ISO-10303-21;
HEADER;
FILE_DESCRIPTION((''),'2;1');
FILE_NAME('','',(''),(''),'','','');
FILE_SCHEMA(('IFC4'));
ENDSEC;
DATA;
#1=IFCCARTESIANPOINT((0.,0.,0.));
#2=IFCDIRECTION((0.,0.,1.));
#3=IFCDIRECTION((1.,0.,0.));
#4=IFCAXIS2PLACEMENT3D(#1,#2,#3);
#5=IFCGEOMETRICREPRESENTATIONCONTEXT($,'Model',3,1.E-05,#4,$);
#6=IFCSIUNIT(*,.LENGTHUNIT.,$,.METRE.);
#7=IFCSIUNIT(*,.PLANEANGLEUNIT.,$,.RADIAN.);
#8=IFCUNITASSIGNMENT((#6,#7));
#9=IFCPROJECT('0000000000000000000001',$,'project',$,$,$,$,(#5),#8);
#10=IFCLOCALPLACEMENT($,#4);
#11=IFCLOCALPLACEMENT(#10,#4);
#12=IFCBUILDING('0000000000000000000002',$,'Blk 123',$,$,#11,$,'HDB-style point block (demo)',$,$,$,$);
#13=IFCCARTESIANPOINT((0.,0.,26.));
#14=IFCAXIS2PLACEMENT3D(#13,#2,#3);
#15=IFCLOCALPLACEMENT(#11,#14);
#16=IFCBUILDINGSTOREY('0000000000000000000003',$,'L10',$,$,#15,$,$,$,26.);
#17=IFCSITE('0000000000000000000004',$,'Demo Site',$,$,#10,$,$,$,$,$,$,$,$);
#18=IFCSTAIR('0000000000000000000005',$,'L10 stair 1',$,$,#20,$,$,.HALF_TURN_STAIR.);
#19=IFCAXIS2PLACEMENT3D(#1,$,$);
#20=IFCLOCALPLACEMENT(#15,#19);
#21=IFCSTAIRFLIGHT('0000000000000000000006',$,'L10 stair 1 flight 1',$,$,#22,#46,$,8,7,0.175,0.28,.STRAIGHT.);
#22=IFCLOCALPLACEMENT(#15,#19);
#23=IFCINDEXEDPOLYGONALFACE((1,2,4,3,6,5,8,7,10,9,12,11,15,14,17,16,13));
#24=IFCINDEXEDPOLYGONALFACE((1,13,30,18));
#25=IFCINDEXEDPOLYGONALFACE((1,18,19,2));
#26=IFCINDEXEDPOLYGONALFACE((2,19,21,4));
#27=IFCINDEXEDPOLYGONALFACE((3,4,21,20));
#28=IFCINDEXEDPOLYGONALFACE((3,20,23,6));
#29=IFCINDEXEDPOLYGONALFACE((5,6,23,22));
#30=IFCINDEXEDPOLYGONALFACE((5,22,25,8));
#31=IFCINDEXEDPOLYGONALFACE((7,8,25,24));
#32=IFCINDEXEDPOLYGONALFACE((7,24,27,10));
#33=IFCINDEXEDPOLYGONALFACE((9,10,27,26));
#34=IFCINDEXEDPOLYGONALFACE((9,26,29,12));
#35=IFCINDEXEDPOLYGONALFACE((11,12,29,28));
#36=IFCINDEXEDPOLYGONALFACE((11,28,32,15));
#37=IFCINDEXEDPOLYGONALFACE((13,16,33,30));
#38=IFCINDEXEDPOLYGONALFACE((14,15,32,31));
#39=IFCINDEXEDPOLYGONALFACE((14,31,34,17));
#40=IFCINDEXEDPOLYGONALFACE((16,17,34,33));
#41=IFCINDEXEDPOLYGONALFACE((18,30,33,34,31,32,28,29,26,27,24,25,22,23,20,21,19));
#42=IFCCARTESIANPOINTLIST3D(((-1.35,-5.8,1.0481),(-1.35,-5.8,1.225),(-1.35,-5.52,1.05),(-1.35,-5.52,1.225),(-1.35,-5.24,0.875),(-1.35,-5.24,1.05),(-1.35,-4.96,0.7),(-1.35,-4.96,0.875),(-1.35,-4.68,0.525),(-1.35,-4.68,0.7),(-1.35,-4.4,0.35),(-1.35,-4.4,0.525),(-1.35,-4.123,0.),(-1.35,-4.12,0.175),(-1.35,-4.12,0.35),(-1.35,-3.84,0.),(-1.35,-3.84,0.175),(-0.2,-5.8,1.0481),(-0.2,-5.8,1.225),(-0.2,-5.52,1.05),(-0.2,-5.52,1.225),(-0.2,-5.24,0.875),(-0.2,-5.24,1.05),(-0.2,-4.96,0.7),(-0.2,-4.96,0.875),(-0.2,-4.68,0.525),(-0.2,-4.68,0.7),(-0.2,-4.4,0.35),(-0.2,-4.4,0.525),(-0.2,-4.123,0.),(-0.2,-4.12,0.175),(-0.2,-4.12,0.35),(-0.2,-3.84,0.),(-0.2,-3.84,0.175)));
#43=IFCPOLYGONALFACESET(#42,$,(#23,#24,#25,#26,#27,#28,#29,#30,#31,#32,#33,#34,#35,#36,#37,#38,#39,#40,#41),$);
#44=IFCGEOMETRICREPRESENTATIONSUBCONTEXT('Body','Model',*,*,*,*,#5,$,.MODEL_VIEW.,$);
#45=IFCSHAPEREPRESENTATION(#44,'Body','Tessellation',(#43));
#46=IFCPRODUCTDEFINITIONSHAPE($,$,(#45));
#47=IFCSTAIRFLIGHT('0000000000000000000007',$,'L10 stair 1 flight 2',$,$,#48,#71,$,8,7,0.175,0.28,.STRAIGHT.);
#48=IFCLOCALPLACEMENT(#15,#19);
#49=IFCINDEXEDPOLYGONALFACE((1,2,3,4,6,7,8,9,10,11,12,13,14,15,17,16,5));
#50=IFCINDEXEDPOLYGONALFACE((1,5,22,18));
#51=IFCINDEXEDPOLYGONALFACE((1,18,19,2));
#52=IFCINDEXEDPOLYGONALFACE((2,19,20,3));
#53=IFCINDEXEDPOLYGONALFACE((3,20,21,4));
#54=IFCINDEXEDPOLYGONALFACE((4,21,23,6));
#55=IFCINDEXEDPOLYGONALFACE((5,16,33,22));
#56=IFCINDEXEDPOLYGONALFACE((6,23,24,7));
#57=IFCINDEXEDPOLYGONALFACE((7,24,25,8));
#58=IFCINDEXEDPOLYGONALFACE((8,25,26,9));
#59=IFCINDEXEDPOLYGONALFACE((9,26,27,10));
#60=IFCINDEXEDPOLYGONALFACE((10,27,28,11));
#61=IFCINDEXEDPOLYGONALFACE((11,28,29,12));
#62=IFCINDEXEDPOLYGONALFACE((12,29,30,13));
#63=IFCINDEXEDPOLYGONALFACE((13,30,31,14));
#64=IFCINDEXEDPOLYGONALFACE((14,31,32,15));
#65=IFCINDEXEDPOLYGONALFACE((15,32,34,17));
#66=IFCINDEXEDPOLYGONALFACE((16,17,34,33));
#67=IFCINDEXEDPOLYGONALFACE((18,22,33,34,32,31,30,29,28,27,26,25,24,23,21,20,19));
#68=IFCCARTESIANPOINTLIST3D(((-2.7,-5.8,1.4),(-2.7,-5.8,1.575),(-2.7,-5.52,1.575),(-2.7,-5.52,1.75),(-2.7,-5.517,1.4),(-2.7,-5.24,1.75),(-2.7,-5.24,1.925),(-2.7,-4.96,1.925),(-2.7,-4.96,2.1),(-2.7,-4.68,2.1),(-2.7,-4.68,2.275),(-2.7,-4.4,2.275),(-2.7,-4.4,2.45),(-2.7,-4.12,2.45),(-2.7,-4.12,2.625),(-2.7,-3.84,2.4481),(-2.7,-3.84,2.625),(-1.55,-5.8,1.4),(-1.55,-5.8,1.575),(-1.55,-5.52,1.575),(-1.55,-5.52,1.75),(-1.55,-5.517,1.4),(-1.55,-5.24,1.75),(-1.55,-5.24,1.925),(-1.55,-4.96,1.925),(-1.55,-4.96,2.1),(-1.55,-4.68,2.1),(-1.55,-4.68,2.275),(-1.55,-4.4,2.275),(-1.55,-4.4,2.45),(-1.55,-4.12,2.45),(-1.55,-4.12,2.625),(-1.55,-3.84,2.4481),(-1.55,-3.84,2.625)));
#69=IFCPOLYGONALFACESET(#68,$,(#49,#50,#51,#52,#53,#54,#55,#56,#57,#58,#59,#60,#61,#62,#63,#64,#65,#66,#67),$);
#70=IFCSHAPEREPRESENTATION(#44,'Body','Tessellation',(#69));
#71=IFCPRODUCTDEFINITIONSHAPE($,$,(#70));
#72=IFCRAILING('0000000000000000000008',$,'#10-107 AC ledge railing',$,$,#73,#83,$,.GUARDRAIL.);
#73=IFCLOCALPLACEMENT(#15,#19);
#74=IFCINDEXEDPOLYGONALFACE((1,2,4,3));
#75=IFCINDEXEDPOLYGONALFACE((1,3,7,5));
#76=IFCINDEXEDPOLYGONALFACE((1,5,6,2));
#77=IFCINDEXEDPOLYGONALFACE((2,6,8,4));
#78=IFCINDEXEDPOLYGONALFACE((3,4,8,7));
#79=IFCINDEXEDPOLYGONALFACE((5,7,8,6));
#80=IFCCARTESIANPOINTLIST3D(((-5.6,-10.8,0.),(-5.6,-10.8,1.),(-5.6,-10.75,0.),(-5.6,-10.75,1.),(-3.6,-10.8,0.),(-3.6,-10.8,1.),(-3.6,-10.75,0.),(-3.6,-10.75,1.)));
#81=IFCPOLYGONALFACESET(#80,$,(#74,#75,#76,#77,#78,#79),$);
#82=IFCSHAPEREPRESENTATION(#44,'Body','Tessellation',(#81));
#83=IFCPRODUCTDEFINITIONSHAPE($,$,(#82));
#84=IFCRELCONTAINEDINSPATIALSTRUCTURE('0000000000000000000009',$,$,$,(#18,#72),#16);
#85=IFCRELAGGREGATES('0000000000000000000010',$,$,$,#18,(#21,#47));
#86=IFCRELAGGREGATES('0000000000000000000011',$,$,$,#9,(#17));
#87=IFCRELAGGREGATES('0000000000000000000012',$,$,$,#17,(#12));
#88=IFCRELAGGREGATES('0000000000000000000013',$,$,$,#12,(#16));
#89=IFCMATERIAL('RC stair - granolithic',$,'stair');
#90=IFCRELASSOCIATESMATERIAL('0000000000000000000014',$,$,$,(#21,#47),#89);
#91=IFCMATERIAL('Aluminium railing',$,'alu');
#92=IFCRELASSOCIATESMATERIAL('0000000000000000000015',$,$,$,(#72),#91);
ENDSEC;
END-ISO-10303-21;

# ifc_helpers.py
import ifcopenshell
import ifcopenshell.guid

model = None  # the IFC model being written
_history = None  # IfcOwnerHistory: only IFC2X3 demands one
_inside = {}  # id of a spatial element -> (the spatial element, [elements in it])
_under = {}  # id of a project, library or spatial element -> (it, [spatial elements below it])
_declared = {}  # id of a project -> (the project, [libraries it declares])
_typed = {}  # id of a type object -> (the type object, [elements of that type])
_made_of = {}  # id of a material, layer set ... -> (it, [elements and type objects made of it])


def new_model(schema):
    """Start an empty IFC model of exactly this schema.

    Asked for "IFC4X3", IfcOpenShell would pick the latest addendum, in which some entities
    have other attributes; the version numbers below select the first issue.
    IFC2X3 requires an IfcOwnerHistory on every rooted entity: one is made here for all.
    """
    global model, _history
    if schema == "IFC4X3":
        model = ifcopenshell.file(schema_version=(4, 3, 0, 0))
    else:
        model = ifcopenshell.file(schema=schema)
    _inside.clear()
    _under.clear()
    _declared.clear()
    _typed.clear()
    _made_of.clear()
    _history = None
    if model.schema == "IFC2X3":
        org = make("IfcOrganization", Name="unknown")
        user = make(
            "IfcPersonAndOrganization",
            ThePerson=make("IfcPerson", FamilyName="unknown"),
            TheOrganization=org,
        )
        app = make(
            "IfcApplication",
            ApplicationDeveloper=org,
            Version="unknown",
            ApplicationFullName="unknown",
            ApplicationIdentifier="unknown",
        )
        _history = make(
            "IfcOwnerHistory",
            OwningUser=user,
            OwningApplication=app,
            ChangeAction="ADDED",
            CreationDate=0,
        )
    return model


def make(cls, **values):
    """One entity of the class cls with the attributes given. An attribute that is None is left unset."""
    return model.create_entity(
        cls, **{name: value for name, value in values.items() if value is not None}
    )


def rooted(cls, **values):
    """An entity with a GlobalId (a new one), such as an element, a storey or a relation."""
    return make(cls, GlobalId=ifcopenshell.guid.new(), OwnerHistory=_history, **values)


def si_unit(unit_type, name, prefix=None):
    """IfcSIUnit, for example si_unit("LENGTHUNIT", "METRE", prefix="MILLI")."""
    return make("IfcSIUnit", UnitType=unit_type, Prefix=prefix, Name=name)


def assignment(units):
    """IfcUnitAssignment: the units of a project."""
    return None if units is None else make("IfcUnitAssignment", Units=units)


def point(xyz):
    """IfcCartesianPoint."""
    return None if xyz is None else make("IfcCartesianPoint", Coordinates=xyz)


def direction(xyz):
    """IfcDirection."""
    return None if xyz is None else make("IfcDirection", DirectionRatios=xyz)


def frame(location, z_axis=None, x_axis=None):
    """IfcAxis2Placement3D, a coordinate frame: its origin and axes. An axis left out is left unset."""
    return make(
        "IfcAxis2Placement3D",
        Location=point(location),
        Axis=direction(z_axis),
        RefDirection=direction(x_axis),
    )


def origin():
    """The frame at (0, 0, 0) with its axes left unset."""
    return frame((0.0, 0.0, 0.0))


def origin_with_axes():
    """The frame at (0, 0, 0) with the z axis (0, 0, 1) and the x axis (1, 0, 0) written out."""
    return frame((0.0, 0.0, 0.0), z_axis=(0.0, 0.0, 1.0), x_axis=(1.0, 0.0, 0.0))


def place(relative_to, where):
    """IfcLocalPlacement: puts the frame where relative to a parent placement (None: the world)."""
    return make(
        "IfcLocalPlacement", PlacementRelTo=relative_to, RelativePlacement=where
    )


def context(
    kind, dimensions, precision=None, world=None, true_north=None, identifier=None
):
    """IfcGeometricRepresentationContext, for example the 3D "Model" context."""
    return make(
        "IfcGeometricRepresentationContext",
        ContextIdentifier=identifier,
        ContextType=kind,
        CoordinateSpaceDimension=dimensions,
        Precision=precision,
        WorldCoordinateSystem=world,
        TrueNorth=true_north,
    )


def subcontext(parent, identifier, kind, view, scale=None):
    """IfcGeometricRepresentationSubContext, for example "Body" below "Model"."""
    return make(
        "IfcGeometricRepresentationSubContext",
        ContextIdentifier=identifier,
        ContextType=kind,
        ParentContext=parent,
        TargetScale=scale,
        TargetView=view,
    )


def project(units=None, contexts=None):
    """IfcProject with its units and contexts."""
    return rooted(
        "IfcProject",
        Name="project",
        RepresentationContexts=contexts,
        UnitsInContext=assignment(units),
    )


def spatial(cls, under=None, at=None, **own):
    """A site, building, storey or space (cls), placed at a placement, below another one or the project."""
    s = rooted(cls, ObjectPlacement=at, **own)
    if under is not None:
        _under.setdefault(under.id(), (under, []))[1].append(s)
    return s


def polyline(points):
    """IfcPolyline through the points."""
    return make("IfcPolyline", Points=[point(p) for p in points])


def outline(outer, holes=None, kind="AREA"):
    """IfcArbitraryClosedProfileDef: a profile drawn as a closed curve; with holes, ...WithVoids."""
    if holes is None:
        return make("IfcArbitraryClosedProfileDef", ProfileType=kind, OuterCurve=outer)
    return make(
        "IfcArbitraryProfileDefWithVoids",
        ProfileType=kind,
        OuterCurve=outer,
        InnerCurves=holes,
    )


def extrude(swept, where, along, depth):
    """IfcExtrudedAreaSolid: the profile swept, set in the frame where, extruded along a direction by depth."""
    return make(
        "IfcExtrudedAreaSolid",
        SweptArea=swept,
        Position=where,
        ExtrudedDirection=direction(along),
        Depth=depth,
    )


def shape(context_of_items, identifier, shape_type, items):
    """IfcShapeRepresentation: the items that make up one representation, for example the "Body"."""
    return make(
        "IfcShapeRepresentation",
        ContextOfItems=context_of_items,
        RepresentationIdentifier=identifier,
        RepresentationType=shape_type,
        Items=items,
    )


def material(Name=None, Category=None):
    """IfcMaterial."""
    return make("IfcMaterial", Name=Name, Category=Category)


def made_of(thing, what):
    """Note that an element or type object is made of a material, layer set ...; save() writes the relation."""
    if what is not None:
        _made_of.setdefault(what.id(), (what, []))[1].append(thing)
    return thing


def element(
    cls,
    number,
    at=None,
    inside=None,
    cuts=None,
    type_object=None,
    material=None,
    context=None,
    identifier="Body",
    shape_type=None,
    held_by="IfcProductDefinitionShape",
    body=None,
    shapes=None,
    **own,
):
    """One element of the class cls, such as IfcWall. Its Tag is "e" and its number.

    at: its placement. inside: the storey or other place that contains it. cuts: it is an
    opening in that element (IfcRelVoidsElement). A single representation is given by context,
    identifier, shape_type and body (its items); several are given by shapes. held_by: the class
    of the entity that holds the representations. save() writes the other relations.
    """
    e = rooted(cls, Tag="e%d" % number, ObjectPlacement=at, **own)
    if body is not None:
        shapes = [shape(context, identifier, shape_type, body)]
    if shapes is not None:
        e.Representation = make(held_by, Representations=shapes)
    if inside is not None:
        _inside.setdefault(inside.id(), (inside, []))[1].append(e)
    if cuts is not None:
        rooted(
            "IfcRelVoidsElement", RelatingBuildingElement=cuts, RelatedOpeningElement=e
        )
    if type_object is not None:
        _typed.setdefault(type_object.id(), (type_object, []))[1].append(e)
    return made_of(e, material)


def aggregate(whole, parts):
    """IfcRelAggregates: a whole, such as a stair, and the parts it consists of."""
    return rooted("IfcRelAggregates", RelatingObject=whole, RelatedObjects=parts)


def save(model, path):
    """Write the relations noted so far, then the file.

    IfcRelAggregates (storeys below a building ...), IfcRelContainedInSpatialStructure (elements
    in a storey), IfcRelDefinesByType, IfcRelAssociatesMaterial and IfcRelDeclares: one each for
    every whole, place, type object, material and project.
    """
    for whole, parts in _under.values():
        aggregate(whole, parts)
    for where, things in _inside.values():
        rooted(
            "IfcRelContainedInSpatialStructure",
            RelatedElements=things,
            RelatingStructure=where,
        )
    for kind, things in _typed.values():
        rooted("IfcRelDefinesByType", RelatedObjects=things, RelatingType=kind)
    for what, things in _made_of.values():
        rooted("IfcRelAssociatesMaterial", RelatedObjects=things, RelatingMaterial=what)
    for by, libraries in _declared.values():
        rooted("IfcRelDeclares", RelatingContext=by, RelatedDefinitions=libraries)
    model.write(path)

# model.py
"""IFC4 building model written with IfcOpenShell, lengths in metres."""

from ifc_helpers import new_model, si_unit, frame, origin, origin_with_axes, place, context, subcontext, project, spatial, polyline, outline, extrude, material, element, aggregate, save


model = new_model("IFC4")

# Units and contexts
model_context = context("Model", 3, precision=1e-05, world=origin_with_axes())
body_context = subcontext(model_context, "Body", "Model", "MODEL_VIEW")
ifc_project = project(units=[si_unit("LENGTHUNIT", "METRE"), si_unit("PLANEANGLEUNIT", "RADIAN")], contexts=[model_context])

# Site, building, storey
site_placement = place(None, origin_with_axes())
site = spatial("IfcSite", under=ifc_project, at=site_placement, Name="Demo Site")
building_placement = place(site_placement, origin_with_axes())
building = spatial("IfcBuilding", under=site, at=building_placement, Name="Blk 123", LongName="HDB-style point block (demo)")
storey_placement = place(building_placement, frame((0.0, 0.0, 26.0), z_axis=(0.0, 0.0, 1.0), x_axis=(1.0, 0.0, 0.0)))
storey = spatial("IfcBuildingStorey", under=building, at=storey_placement, Name="L10", Elevation=26.0)

# Stair
stair_placement = place(storey_placement, frame((-2.7, -7.1, 0.0), z_axis=(0.0, 0.0, 1.0), x_axis=(1.0, 0.0, 0.0)))
stair = element("IfcStair", 1, at=stair_placement, inside=storey, Name="L10 stair 1", PredefinedType="HALF_TURN_STAIR")
ifc_material_1 = material(Name="RC stair - granolithic", Category="stair")

# Stair flights
stair_flight_1_placement = place(stair_placement, frame((2.5, 3.26, 0.0), z_axis=(0.0, 0.0, 1.0), x_axis=(1.0, 0.0, 0.0)))
stair_flight_1 = element("IfcStairFlight", 2, at=stair_flight_1_placement, material=ifc_material_1, Name="L10 stair 1 flight 1", NumberOfRisers=8, NumberOfTreads=7, PredefinedType="STRAIGHT", RiserHeight=0.175, TreadLength=0.28, context=body_context, shape_type="SweptSolid", body=[
    extrude(outline(polyline([(0.0, 0.0), (0.0, 0.175), (0.28, 0.175), (0.28, 0.35), (0.56, 0.35), (0.56, 0.525), (0.84, 0.525), (0.84, 0.7), (1.12, 0.7), (1.12, 0.875), (1.4, 0.875), (1.4, 1.05), (1.68, 1.05), (1.68, 1.225), (1.96, 1.225), (1.96, 1.4), (1.96, 1.0481), (0.283, 0.0), (0.0, 0.0)])), frame((0.0, 0.0, 0.0), z_axis=(-1.0, 0.0, 0.0), x_axis=(0.0, -1.0, 0.0)), (0.0, 0.0, 1.0), 1.15),
])
stair_flight_2_placement = place(stair_placement, frame((0.0, 1.3, 1.4), z_axis=(0.0, 0.0, 1.0), x_axis=(1.0, 0.0, 0.0)))
stair_flight_2 = element("IfcStairFlight", 3, at=stair_flight_2_placement, material=ifc_material_1, Name="L10 stair 1 flight 2", NumberOfRisers=8, NumberOfTreads=7, PredefinedType="STRAIGHT", RiserHeight=0.175, TreadLength=0.28, context=body_context, shape_type="SweptSolid", body=[
    extrude(outline(polyline([(0.0, 0.0), (0.0, 0.175), (0.28, 0.175), (0.28, 0.35), (0.56, 0.35), (0.56, 0.525), (0.84, 0.525), (0.84, 0.7), (1.12, 0.7), (1.12, 0.875), (1.4, 0.875), (1.4, 1.05), (1.68, 1.05), (1.68, 1.225), (1.96, 1.225), (1.96, 1.4), (1.96, 1.0481), (0.283, 0.0), (0.0, 0.0)])), frame((0.0, 0.0, 0.0), z_axis=(1.0, 0.0, 0.0), x_axis=(0.0, 1.0, 0.0)), (0.0, 0.0, 1.0), 1.15),
])

# Railing
aggregate(stair, [stair_flight_1, stair_flight_2])
ifc_material_2 = material(Name="Aluminium railing", Category="alu")
railing_1_placement = place(storey_placement, frame((-4.6, -10.775, 0.0), z_axis=(0.0, 0.0, 1.0), x_axis=(1.0, 0.0, 0.0)))
element("IfcRailing", 4, at=railing_1_placement, inside=storey, material=ifc_material_2, Name="#10-107 AC ledge railing", PredefinedType="GUARDRAIL", context=body_context, shape_type="SweptSolid", body=[
    extrude(outline(polyline([(-1.0, 0.025), (-1.0, -0.025), (1.0, -0.025), (1.0, 0.025), (-1.0, 0.025)])), origin(), (0.0, 0.0, 1.0), 1.0),
])

save(model, "model.ifc")
